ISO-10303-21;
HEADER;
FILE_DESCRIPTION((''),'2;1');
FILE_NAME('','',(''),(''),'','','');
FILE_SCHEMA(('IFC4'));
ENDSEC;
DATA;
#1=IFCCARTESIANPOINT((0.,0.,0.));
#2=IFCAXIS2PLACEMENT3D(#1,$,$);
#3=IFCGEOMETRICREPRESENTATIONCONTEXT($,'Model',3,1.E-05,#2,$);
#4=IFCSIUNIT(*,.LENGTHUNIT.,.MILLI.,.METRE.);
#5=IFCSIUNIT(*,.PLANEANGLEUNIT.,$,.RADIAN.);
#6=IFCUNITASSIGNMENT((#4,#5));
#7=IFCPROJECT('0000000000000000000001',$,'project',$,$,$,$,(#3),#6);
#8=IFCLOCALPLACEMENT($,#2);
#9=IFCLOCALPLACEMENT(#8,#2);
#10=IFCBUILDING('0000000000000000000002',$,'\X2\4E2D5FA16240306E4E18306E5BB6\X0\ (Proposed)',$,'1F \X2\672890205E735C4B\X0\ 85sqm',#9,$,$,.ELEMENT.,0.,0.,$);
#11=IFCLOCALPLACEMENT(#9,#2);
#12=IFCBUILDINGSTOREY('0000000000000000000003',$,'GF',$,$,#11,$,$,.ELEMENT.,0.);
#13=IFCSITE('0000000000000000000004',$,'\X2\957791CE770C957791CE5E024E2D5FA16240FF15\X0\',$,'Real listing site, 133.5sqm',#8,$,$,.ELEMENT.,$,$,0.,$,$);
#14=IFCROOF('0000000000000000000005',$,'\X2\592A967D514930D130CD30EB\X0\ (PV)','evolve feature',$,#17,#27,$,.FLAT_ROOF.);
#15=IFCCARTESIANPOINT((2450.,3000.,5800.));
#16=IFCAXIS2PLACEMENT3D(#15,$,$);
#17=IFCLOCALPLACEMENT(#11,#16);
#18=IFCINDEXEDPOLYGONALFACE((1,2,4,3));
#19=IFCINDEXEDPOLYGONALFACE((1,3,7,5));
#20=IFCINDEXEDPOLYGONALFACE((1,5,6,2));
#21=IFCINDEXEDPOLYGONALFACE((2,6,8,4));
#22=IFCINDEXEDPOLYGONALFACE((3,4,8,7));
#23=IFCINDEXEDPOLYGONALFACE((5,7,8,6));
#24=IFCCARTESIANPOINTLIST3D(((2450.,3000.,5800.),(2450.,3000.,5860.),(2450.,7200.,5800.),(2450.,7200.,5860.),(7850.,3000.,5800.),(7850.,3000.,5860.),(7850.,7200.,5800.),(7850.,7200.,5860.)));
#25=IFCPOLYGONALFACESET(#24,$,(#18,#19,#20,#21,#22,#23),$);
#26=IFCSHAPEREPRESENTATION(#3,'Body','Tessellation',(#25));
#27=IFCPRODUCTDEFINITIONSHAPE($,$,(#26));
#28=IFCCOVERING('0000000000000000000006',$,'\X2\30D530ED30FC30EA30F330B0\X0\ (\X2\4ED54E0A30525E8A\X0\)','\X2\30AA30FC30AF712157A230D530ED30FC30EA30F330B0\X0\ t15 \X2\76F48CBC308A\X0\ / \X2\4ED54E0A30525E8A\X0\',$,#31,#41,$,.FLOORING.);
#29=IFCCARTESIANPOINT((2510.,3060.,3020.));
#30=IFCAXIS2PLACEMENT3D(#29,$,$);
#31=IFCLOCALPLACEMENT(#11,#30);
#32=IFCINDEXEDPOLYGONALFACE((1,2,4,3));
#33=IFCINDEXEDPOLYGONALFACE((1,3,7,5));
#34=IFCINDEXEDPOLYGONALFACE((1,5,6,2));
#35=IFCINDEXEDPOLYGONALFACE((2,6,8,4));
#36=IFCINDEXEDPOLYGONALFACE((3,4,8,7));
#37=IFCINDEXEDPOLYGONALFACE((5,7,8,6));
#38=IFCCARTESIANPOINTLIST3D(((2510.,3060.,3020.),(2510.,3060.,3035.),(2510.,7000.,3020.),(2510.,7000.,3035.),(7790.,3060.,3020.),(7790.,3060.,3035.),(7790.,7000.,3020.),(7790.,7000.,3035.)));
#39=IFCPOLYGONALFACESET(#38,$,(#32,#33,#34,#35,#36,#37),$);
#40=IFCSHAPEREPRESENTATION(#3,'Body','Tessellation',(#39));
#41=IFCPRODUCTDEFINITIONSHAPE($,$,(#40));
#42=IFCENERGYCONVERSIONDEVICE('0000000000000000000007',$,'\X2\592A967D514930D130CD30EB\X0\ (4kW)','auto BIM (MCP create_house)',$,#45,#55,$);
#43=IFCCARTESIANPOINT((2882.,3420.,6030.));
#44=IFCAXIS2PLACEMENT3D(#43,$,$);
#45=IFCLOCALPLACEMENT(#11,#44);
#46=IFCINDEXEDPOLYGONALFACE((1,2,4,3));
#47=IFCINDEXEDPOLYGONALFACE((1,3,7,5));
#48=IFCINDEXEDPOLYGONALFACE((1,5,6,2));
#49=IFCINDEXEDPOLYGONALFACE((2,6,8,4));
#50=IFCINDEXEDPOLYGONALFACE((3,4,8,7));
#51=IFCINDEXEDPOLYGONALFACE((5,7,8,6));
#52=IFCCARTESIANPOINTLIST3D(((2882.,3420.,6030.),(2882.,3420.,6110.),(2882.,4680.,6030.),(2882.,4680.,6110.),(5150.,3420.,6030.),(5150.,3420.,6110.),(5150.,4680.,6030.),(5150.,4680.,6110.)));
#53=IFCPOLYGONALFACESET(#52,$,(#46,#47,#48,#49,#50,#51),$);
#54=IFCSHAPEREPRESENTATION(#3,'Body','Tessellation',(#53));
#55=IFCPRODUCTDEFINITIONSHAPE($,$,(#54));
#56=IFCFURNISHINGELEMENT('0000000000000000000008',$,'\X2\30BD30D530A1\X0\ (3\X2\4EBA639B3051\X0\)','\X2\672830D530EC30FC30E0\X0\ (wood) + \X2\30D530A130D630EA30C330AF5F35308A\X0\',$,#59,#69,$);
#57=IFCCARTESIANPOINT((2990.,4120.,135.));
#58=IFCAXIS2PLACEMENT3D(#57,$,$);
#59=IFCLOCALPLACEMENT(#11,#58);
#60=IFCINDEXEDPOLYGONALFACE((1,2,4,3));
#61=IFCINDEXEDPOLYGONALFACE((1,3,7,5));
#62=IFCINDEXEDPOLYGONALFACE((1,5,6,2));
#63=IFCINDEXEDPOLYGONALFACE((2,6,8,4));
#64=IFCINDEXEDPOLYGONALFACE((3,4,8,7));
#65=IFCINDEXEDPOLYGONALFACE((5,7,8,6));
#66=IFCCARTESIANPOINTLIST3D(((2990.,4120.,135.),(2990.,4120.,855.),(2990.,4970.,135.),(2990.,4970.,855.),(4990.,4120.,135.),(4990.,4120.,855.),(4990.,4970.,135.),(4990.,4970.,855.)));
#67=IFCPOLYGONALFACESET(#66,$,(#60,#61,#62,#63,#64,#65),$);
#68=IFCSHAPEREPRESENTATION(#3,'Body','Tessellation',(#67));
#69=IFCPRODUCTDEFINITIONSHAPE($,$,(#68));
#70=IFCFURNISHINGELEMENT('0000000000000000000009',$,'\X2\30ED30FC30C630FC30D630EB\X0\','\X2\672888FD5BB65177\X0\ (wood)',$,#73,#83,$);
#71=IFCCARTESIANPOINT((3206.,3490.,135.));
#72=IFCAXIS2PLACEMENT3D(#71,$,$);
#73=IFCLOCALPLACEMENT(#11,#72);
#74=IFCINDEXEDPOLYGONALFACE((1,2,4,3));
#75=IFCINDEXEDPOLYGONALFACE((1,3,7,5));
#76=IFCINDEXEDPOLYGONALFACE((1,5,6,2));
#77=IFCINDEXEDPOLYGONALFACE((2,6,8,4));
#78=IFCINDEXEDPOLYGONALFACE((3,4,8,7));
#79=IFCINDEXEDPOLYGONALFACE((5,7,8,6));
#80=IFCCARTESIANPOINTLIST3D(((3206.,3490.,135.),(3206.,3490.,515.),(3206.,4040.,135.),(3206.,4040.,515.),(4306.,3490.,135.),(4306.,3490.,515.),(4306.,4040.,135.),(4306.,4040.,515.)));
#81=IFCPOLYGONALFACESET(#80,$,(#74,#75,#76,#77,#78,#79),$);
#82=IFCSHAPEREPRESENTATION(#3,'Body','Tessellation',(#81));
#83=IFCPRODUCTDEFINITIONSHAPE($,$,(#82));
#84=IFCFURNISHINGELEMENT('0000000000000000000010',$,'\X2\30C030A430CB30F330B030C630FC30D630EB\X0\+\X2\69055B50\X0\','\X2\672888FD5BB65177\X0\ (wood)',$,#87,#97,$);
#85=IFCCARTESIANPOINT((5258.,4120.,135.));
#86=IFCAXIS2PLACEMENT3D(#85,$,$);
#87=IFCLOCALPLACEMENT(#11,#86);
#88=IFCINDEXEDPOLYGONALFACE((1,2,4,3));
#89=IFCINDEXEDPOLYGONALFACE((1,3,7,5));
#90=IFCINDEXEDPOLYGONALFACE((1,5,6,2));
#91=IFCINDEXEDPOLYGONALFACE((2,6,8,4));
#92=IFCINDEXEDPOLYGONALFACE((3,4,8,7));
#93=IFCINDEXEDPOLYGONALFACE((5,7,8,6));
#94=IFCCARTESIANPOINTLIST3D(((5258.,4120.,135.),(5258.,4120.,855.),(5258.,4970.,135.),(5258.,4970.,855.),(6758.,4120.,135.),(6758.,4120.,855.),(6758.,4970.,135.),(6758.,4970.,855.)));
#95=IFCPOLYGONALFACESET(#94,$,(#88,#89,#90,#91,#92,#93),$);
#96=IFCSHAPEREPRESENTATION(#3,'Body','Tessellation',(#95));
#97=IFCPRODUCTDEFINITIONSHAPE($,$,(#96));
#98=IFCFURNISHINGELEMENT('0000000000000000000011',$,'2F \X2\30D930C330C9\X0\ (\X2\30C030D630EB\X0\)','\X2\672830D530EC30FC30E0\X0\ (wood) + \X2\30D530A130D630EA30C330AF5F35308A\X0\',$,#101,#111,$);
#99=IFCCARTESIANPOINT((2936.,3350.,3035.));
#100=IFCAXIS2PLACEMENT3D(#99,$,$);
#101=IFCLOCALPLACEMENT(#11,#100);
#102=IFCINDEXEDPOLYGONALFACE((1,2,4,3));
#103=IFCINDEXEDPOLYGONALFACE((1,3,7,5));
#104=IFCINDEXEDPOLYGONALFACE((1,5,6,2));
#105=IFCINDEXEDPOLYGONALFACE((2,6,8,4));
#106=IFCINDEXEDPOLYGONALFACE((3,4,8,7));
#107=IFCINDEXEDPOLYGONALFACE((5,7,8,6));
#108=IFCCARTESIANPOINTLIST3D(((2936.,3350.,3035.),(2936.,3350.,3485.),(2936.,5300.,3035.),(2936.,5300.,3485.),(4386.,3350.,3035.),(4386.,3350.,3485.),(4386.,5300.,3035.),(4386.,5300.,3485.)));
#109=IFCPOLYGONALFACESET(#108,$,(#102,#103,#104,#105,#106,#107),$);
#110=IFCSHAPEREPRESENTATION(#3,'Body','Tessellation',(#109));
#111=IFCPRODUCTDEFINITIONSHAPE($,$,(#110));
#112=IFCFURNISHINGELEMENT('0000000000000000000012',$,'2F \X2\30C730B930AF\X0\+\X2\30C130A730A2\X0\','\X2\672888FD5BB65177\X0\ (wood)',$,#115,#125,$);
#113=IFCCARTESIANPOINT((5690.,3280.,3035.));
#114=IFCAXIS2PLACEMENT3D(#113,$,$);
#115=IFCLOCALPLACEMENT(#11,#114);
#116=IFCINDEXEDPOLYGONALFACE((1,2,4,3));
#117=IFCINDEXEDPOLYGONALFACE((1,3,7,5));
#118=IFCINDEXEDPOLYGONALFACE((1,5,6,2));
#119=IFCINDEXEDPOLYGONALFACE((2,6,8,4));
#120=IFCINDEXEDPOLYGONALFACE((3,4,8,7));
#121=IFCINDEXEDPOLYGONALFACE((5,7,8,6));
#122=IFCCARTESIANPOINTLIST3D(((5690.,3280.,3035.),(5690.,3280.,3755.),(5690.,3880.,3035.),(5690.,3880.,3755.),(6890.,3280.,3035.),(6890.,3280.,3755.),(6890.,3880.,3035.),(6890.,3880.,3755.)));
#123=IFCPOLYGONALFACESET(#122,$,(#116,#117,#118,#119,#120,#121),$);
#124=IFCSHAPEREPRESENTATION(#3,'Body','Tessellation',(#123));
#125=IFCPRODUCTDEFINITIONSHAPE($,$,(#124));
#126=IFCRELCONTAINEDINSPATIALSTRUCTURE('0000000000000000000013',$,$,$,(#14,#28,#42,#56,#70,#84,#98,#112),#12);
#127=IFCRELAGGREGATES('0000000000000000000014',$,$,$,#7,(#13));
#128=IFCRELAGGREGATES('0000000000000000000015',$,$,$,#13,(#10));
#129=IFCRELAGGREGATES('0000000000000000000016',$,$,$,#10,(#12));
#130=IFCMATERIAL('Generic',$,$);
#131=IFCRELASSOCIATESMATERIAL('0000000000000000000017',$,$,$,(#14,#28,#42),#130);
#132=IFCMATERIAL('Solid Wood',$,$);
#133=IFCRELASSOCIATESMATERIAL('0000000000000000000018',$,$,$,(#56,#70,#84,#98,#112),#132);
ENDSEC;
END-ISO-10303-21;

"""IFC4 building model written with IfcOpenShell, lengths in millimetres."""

from ifc_helpers import new_model, si_unit, frame, frame_2d, origin, place, context, project, spatial, rectangle, extrude, material, element, save


model = new_model("IFC4")

# Units and contexts
model_context = context("Model", 3, precision=1e-05, world=origin())
ifc_project = project(units=[si_unit("LENGTHUNIT", "METRE", prefix="MILLI"), si_unit("PLANEANGLEUNIT", "RADIAN")], contexts=[model_context])

# Site, building, storey
site_placement = place(None, origin())
site = spatial("IfcSite", under=ifc_project, at=site_placement, Name="長野県長野市中御所５", ObjectType="Real listing site, 133.5sqm", CompositionType="ELEMENT", RefElevation=0.0)
building_placement = place(site_placement, origin())
building = spatial("IfcBuilding", under=site, at=building_placement, Name="中御所の丘の家 (Proposed)", ObjectType="1F 木造平屋 85sqm", CompositionType="ELEMENT", ElevationOfRefHeight=0.0, ElevationOfTerrain=0.0)
storey_placement = place(building_placement, origin())
storey = spatial("IfcBuildingStorey", under=building, at=storey_placement, Name="GF", CompositionType="ELEMENT", Elevation=0.0)

# Shared definitions
ifc_material_1 = material(Name="Solid Wood")

# Shared definitions
ifc_material_2 = material(Name="Generic")

# Roof
roof_placement = place(storey_placement, frame((2450.0, 3000.0, 5800.0)))
element("IfcRoof", 1, at=roof_placement, inside=storey, material=ifc_material_2, Name="太陽光パネル (PV)", Description="evolve feature", PredefinedType="FLAT_ROOF", context=model_context, shape_type="SweptSolid", body=[
    extrude(rectangle(XDim=5400.0, YDim=4200.0, at=frame_2d((2700.0, 2100.0))), frame((2450.0, 3000.0, 5800.0)), (0.0, 0.0, 1.0), 60.0),
])

# Covering
covering_placement = place(storey_placement, frame((2510.0, 3060.0, 3020.0)))
element("IfcCovering", 2, at=covering_placement, inside=storey, material=ifc_material_2, Name="フローリング (仕上げ床)", Description="オーク無垢フローリング t15 直貼り / 仕上げ床", PredefinedType="FLOORING", context=model_context, shape_type="SweptSolid", body=[
    extrude(rectangle(XDim=5280.0, YDim=3940.0, at=frame_2d((2640.0, 1970.0))), frame((2510.0, 3060.0, 3020.0)), (0.0, 0.0, 1.0), 15.0),
])

# Energy conversion device
energy_conversion_device_placement = place(storey_placement, frame((2882.0, 3420.0, 6030.0)))
element("IfcEnergyConversionDevice", 3, at=energy_conversion_device_placement, inside=storey, material=ifc_material_2, Name="太陽光パネル (4kW)", Description="auto BIM (MCP create_house)", context=model_context, shape_type="SweptSolid", body=[
    extrude(rectangle(XDim=2268.0, YDim=1260.0, at=frame_2d((1134.0, 630.0))), frame((2882.0, 3420.0, 6030.0)), (0.0, 0.0, 1.0), 80.0),
])

# Furnishing elements
furnishing_1_placement = place(storey_placement, frame((2990.0, 4120.0, 135.0)))
element("IfcFurnishingElement", 4, at=furnishing_1_placement, inside=storey, material=ifc_material_1, Name="ソファ (3人掛け)", Description="木フレーム (wood) + ファブリック張り", context=model_context, shape_type="SweptSolid", body=[
    extrude(rectangle(XDim=2000.0, YDim=850.0, at=frame_2d((1000.0, 425.0))), frame((2990.0, 4120.0, 135.0)), (0.0, 0.0, 1.0), 720.0),
])
furnishing_2_placement = place(storey_placement, frame((3206.0, 3490.0, 135.0)))
element("IfcFurnishingElement", 5, at=furnishing_2_placement, inside=storey, material=ifc_material_1, Name="ローテーブル", Description="木製家具 (wood)", context=model_context, shape_type="SweptSolid", body=[
    extrude(rectangle(XDim=1100.0, YDim=550.0, at=frame_2d((550.0, 275.0))), frame((3206.0, 3490.0, 135.0)), (0.0, 0.0, 1.0), 380.0),
])
furnishing_3_placement = place(storey_placement, frame((5258.0, 4120.0, 135.0)))
element("IfcFurnishingElement", 6, at=furnishing_3_placement, inside=storey, material=ifc_material_1, Name="ダイニングテーブル+椅子", Description="木製家具 (wood)", context=model_context, shape_type="SweptSolid", body=[
    extrude(rectangle(XDim=1500.0, YDim=850.0, at=frame_2d((750.0, 425.0))), frame((5258.0, 4120.0, 135.0)), (0.0, 0.0, 1.0), 720.0),
])
furnishing_4_placement = place(storey_placement, frame((2936.0, 3350.0, 3035.0)))
element("IfcFurnishingElement", 7, at=furnishing_4_placement, inside=storey, material=ifc_material_1, Name="2F ベッド (ダブル)", Description="木フレーム (wood) + ファブリック張り", context=model_context, shape_type="SweptSolid", body=[
    extrude(rectangle(XDim=1450.0, YDim=1950.0, at=frame_2d((725.0, 975.0))), frame((2936.0, 3350.0, 3035.0)), (0.0, 0.0, 1.0), 450.0),
])
furnishing_5_placement = place(storey_placement, frame((5690.0, 3280.0, 3035.0)))
element("IfcFurnishingElement", 8, at=furnishing_5_placement, inside=storey, material=ifc_material_1, Name="2F デスク+チェア", Description="木製家具 (wood)", context=model_context, shape_type="SweptSolid", body=[
    extrude(rectangle(XDim=1200.0, YDim=600.0, at=frame_2d((600.0, 300.0))), frame((5690.0, 3280.0, 3035.0)), (0.0, 0.0, 1.0), 720.0),
])

save(model, "model.ifc")
